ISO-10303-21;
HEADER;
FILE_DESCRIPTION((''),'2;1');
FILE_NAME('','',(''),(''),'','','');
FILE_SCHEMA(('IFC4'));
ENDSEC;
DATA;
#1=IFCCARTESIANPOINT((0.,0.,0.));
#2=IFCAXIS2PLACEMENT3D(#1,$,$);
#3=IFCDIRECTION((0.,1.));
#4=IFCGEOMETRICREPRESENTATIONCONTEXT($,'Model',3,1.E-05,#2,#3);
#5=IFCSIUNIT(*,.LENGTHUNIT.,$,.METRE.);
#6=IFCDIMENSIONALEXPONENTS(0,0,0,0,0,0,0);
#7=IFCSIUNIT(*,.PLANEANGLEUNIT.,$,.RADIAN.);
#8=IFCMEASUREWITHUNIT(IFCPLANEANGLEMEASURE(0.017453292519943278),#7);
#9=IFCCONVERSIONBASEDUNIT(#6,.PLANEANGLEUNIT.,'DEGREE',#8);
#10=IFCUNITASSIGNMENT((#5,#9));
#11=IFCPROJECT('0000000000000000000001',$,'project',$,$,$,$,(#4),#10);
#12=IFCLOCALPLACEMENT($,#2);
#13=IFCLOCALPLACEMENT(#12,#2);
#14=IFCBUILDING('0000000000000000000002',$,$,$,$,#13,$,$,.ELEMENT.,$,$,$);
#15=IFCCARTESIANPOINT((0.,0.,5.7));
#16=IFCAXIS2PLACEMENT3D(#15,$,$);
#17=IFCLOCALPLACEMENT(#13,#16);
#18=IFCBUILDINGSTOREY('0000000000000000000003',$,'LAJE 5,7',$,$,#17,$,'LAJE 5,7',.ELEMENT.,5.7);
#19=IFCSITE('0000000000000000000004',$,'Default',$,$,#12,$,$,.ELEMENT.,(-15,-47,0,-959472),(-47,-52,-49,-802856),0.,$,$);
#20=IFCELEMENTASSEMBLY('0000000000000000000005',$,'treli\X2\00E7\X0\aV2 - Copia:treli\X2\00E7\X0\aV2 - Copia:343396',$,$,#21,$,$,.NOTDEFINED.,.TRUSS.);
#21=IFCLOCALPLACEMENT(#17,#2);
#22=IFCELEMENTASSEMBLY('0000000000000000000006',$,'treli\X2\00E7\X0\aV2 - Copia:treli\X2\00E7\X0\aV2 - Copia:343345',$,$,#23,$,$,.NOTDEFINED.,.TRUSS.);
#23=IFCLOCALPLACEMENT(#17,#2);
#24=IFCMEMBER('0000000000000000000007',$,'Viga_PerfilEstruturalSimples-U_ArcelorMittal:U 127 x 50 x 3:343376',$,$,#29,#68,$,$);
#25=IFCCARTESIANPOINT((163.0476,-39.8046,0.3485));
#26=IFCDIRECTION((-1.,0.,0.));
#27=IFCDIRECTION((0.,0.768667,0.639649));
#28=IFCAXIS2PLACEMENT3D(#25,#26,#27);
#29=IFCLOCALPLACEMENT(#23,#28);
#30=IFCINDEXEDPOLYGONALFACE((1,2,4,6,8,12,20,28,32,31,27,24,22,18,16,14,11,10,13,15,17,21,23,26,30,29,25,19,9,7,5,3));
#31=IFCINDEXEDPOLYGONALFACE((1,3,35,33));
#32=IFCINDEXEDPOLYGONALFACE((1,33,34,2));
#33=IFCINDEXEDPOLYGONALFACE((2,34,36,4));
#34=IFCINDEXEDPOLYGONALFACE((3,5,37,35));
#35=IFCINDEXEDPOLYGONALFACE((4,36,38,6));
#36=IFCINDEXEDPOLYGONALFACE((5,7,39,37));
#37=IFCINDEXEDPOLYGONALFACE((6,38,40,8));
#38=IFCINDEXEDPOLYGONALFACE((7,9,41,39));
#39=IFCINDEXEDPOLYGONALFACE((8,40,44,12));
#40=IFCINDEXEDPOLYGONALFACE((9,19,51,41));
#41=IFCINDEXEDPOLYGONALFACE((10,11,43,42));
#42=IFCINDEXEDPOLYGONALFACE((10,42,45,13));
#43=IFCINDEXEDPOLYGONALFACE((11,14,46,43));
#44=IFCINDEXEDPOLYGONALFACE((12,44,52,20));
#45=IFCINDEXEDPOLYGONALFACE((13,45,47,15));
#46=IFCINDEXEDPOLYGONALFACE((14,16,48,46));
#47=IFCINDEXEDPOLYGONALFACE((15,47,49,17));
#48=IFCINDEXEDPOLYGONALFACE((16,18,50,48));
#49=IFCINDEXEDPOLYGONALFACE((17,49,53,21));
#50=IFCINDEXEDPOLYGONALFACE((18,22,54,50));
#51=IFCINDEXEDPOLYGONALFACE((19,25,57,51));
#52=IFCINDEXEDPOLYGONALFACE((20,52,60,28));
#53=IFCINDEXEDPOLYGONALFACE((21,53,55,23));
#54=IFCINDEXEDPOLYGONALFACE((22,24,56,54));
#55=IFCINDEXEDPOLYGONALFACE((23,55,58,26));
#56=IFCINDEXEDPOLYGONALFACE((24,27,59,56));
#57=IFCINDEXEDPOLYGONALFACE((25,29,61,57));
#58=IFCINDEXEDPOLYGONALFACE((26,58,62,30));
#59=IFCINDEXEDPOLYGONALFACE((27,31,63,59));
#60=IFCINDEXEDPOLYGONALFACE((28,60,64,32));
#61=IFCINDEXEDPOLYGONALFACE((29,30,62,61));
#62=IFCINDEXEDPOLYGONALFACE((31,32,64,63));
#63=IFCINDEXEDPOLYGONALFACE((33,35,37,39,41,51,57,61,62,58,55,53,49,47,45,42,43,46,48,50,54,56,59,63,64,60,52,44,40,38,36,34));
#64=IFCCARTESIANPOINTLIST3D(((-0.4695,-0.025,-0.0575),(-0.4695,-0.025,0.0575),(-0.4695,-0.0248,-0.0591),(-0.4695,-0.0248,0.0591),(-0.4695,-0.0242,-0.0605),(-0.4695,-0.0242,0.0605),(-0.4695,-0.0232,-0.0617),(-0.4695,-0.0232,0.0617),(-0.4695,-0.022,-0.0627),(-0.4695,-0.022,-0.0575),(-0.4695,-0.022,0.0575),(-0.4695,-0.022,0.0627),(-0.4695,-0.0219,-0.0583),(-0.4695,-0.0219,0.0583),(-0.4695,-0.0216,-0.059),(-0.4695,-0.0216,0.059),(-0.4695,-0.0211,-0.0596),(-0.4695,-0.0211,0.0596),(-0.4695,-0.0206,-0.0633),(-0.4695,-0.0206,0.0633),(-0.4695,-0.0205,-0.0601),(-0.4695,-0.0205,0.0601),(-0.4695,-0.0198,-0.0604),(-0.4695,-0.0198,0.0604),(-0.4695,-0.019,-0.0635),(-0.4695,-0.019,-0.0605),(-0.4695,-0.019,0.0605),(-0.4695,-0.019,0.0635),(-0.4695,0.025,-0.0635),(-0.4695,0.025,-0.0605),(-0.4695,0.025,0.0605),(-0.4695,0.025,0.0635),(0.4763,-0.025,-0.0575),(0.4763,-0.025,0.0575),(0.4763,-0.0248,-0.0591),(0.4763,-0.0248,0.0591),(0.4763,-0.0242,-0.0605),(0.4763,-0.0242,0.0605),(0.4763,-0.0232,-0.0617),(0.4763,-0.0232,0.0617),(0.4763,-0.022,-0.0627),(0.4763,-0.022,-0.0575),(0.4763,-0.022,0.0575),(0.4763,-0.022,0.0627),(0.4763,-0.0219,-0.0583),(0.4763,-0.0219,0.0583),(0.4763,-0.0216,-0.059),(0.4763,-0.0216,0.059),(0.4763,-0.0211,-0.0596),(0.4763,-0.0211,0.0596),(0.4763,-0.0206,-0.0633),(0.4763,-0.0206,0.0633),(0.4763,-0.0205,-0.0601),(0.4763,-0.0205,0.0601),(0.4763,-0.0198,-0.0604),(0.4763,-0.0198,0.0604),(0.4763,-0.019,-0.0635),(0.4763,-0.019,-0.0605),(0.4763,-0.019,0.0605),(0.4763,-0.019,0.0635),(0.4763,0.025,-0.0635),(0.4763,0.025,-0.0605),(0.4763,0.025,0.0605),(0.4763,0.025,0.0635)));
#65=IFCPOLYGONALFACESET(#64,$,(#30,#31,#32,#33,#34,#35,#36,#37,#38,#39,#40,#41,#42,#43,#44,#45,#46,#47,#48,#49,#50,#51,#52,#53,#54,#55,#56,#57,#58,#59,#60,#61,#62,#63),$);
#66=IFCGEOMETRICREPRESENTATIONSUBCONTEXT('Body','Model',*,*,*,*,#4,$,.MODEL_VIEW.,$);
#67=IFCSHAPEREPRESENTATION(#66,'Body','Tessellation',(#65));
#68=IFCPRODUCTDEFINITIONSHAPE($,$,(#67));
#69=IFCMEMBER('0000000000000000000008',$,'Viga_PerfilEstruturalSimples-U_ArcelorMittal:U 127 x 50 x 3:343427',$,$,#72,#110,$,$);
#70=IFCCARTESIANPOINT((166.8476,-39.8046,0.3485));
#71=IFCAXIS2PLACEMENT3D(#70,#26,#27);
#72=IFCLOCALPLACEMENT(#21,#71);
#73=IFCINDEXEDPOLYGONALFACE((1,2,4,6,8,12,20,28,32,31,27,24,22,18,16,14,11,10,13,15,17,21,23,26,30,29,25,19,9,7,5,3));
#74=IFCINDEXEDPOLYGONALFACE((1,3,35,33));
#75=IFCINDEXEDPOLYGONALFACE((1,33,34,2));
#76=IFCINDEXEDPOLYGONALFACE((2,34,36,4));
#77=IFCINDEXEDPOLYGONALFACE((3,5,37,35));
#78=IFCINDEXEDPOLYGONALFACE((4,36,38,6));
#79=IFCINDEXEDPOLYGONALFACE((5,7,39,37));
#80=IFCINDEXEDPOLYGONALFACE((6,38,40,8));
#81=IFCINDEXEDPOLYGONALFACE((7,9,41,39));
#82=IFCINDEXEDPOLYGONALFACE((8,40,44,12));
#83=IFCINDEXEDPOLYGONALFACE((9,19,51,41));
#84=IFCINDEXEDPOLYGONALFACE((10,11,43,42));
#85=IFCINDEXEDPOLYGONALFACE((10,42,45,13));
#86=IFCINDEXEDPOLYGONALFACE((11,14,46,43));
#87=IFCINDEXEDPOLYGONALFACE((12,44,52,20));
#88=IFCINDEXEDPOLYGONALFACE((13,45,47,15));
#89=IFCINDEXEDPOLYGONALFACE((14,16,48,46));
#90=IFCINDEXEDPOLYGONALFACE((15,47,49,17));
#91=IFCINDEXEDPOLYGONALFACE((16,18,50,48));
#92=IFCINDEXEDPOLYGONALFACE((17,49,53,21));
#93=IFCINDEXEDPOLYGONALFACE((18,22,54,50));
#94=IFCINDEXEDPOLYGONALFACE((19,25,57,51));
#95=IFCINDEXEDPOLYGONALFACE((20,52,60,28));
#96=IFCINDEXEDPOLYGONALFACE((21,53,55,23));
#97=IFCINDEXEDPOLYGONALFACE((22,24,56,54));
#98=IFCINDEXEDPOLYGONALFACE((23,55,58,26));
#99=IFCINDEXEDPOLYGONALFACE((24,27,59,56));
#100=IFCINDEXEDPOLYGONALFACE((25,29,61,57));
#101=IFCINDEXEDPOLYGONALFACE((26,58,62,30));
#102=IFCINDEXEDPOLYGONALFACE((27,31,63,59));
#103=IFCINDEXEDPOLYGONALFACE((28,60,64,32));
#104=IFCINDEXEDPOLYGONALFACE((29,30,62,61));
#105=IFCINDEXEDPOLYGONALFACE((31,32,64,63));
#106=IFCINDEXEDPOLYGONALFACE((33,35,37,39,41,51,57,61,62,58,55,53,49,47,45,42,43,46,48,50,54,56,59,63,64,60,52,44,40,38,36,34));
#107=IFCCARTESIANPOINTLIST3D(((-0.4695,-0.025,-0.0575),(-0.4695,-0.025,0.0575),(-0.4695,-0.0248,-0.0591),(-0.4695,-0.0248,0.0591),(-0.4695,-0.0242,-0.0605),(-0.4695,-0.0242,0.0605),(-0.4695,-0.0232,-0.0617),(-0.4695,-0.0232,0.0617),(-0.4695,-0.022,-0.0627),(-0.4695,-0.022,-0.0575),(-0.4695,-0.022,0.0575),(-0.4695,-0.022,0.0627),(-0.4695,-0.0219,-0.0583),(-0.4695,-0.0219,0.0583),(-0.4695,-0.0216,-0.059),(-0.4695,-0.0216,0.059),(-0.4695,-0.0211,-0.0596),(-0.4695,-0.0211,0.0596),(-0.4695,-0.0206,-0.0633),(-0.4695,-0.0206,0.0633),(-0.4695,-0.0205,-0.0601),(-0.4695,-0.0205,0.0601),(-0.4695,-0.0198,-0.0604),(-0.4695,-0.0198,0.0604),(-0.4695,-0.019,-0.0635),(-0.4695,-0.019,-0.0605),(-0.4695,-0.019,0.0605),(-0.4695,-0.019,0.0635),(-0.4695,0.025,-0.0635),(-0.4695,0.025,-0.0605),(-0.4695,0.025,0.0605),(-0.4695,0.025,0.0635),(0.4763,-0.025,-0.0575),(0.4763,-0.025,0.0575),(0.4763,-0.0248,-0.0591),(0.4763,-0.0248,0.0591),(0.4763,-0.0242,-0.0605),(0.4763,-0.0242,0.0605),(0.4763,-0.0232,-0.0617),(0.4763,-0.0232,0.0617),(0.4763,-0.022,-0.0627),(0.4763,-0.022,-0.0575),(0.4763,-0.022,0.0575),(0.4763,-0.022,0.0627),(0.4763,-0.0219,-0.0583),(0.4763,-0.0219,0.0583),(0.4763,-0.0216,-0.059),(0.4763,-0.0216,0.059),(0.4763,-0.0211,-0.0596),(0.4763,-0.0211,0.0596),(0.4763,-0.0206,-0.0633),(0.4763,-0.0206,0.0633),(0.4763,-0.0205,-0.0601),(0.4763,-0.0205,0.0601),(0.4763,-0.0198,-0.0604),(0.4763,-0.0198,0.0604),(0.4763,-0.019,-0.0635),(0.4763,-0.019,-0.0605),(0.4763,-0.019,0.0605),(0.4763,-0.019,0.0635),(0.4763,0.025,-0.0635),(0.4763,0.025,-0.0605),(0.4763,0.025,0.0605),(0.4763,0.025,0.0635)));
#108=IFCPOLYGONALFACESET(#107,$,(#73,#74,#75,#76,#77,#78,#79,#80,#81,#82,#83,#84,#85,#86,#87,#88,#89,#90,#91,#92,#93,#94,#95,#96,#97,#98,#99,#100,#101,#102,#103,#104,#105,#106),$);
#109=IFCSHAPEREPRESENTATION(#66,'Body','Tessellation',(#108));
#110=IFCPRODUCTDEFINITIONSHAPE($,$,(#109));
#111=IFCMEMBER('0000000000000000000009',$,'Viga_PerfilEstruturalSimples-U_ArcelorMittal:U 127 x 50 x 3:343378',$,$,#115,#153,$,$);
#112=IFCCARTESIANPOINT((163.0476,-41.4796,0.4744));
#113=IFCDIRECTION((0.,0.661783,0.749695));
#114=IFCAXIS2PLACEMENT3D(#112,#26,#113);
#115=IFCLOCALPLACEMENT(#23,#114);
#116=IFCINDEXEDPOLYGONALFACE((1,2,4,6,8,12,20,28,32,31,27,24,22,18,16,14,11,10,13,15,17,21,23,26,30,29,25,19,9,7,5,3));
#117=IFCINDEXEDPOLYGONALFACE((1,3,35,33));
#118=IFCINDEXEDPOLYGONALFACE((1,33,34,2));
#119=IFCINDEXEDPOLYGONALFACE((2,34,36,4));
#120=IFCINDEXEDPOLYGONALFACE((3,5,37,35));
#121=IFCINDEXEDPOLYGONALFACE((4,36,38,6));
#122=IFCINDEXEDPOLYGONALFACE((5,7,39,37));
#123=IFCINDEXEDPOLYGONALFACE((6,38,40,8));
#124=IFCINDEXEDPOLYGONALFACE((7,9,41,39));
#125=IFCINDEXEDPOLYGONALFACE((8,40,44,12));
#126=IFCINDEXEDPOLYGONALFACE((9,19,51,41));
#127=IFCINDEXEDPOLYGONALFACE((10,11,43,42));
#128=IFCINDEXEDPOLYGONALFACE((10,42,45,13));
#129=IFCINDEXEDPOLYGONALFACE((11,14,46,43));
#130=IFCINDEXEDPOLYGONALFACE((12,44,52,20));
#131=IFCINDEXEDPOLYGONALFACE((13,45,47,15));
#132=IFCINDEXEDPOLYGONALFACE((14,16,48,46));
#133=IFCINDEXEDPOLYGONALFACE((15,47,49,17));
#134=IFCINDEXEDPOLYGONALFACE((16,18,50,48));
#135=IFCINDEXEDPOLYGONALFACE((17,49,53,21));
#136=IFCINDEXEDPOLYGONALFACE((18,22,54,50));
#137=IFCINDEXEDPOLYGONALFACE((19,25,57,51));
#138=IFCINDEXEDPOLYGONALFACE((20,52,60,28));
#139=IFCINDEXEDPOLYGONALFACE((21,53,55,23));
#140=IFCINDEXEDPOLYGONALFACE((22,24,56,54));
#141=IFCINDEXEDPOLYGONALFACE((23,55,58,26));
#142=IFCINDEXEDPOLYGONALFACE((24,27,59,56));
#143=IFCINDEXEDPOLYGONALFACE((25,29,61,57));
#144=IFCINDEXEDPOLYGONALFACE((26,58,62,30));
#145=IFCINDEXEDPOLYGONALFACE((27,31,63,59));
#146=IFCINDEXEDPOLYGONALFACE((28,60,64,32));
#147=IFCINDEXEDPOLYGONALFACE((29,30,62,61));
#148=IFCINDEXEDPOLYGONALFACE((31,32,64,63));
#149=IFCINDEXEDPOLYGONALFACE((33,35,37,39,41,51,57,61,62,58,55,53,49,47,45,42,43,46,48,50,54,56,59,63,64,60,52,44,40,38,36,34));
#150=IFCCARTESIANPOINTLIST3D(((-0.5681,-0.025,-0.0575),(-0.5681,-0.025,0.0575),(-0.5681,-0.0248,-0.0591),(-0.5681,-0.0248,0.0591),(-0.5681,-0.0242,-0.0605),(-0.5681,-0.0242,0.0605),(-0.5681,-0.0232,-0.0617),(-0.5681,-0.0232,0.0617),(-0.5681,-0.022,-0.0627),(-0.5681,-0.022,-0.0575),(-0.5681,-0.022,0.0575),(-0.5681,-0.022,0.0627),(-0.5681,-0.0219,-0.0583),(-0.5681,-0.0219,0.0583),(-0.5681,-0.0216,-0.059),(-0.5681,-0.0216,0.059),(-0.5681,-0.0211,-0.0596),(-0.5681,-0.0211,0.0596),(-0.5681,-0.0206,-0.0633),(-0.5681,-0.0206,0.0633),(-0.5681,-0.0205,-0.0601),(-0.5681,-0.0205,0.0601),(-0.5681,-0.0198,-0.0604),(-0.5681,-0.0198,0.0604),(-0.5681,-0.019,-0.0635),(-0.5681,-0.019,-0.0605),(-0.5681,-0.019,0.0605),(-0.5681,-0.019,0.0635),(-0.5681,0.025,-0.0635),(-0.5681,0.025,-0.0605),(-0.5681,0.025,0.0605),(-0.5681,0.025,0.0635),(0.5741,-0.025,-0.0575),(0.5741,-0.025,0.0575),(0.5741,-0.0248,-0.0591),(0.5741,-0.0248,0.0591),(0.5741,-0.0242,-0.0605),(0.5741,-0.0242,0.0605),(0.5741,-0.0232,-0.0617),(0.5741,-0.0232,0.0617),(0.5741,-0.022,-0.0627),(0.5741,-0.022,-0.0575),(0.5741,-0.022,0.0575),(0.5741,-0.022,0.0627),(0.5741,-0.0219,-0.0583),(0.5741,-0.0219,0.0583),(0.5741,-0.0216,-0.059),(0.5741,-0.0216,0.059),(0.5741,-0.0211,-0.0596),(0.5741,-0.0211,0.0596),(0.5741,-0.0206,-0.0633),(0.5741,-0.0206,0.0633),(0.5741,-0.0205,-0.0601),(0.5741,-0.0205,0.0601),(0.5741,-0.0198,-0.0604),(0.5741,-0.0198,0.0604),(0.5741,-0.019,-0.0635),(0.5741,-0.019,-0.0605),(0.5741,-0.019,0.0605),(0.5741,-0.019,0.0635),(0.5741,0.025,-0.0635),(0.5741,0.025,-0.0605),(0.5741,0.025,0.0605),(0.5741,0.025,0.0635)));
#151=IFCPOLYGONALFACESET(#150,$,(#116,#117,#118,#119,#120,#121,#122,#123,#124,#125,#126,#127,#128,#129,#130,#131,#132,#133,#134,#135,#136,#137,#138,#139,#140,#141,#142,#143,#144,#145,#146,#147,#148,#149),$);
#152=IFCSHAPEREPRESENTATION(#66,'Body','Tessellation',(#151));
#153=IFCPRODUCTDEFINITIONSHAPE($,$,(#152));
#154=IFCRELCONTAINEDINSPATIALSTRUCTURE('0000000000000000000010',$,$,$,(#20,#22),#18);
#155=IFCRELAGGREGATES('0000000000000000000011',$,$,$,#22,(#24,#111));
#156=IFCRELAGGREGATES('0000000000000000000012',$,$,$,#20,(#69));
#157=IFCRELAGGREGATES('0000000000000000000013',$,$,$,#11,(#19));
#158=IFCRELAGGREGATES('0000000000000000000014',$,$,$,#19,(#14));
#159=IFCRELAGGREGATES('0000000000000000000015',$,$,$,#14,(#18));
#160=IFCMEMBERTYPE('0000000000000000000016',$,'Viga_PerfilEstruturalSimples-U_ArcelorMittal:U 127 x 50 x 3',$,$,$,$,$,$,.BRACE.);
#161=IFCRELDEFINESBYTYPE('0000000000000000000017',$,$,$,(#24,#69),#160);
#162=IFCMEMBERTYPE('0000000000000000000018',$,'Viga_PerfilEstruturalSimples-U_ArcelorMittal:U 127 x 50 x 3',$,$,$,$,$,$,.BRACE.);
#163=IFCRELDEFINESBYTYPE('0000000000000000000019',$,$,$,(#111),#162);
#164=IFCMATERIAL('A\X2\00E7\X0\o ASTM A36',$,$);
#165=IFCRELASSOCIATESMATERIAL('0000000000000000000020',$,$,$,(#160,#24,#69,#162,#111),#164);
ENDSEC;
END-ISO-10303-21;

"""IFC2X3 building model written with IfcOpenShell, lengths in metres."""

from ifc_helpers import new_model, entity, si_unit, converted_unit, direction, frame, frame_2d, origin, place, context, subcontext, project, spatial, polyline, circle_curve, parameter, trimmed, segment, composite_curve, outline, extrude, source, transform, mapped, material, type_object, type_shapes, element, aggregate, save


model = new_model("IFC2X3")

# Units and contexts
model_context = context("Model", 3, precision=1e-05, world=origin(), true_north=direction((0.0, 1.0)))
body_context = subcontext(model_context, "Body", "Model", "MODEL_VIEW")
ifc_project = project(units=[si_unit("LENGTHUNIT", "METRE"), converted_unit("PLANEANGLEUNIT", "DEGREE", entity("IfcPlaneAngleMeasure", 0.017453292519943278), si_unit("PLANEANGLEUNIT", "RADIAN"), dimensions=[0, 0, 0, 0, 0, 0, 0])], contexts=[model_context])

# Site, building, storey
site_placement = place(None, origin())
site = spatial("IfcSite", under=ifc_project, at=site_placement, Name="Default", CompositionType="ELEMENT", RefLatitude=(-15, -47, 0, -959472), RefLongitude=(-47, -52, -49, -802856), RefElevation=0.0)
building_placement = place(site_placement, origin())
building = spatial("IfcBuilding", under=site, at=building_placement, CompositionType="ELEMENT")
storey_placement = place(building_placement, frame((0.0, 0.0, 5.7)))
storey = spatial("IfcBuildingStorey", under=building, at=storey_placement, Name="LAJE 5,7", LongName="LAJE 5,7", CompositionType="ELEMENT", Elevation=5.7)

# Element assembly
assembly_1_placement = place(storey_placement, origin())
assembly_1 = element("IfcElementAssembly", 1, at=assembly_1_placement, inside=storey, Name="treliçaV2 - Copia:treliçaV2 - Copia:343396", AssemblyPlace="NOTDEFINED", PredefinedType="TRUSS")
ifc_material = material(Name="Aço ASTM A36")

# Element assembly
assembly_2_placement = place(storey_placement, origin())
assembly_2 = element("IfcElementAssembly", 2, at=assembly_2_placement, inside=storey, Name="treliçaV2 - Copia:treliçaV2 - Copia:343345", AssemblyPlace="NOTDEFINED", PredefinedType="TRUSS")

# Members
member_type_1 = type_object("IfcMemberType", Name="Viga_PerfilEstruturalSimples-U_ArcelorMittal:U 127 x 50 x 3", PredefinedType="BRACE", material=ifc_material)
shared_shape_1 = source(origin(), body_context, "Body", "SweptSolid", [
    extrude(outline(composite_curve([segment(polyline([(-0.0575, -0.0192), (0.0575, -0.0192)]), True, "CONTINUOUS"), segment(trimmed(circle_curve(frame_2d((0.0575, -0.0132), x_axis=(0.0, 1.0)), 0.006), [parameter(180.0)], [parameter(270.0)], True, "PARAMETER"), True, "CONTINUOUS"), segment(polyline([(0.0635, -0.0132), (0.0635, 0.0308)]), True, "CONTINUOUS"), segment(polyline([(0.0635, 0.0308), (0.0605, 0.0308)]), True, "CONTINUOUS"), segment(polyline([(0.0605, 0.0308), (0.0605, -0.0132)]), True, "CONTINUOUS"), segment(trimmed(circle_curve(frame_2d((0.0575, -0.0132), x_axis=(0.0, 1.0)), 0.003), [parameter(180.0)], [parameter(270.0)], True, "PARAMETER"), False, "CONTINUOUS"), segment(polyline([(0.0575, -0.0162), (-0.0575, -0.0162)]), True, "CONTINUOUS"), segment(trimmed(circle_curve(frame_2d((-0.0575, -0.0132), x_axis=(0.0, 1.0)), 0.003), [parameter(90.0)], [parameter(180.0)], True, "PARAMETER"), False, "CONTINUOUS"), segment(polyline([(-0.0605, -0.0132), (-0.0605, 0.0308)]), True, "CONTINUOUS"), segment(polyline([(-0.0605, 0.0308), (-0.0635, 0.0308)]), True, "CONTINUOUS"), segment(polyline([(-0.0635, 0.0308), (-0.0635, -0.0132)]), True, "CONTINUOUS"), segment(trimmed(circle_curve(frame_2d((-0.0575, -0.0132), x_axis=(0.0, 1.0)), 0.006), [parameter(90.0)], [parameter(180.0)], True, "PARAMETER"), True, "CONTINUOUS")], self_intersect=False)), frame((-0.4695, -0.0058, 0.0), z_axis=(1.0, 0.0, 0.0), x_axis=(0.0, 0.0, -1.0)), (0.0, 0.0, 1.0), 0.9459),
])
type_shapes(member_type_1, [shared_shape_1])
member_1_placement = place(assembly_2_placement, frame((163.0476, -39.8046, 0.3485), z_axis=(-1.0, 0.0, 0.0), x_axis=(0.0, 0.768667, 0.639649)))
member_1 = element("IfcMember", 3, at=member_1_placement, type_object=member_type_1, material=ifc_material, Name="Viga_PerfilEstruturalSimples-U_ArcelorMittal:U 127 x 50 x 3:343376", context=body_context, shape_type="MappedRepresentation", body=[
    mapped(shared_shape_1, transform((0.0, 0.0, 0.0), scale=1.0)),
])
member_2_placement = place(assembly_1_placement, frame((166.8476, -39.8046, 0.3485), z_axis=(-1.0, 0.0, 0.0), x_axis=(0.0, 0.768667, 0.639649)))
member_2 = element("IfcMember", 4, at=member_2_placement, type_object=member_type_1, material=ifc_material, Name="Viga_PerfilEstruturalSimples-U_ArcelorMittal:U 127 x 50 x 3:343427", context=body_context, shape_type="MappedRepresentation", body=[
    mapped(shared_shape_1, transform((0.0, 0.0, 0.0), scale=1.0)),
])
member_type_2 = type_object("IfcMemberType", Name="Viga_PerfilEstruturalSimples-U_ArcelorMittal:U 127 x 50 x 3", PredefinedType="BRACE", material=ifc_material)
shared_shape_2 = source(origin(), body_context, "Body", "SweptSolid", [
    extrude(outline(composite_curve([segment(polyline([(-0.0575, -0.0192), (0.0575, -0.0192)]), True, "CONTINUOUS"), segment(trimmed(circle_curve(frame_2d((0.0575, -0.0132), x_axis=(0.0, 1.0)), 0.006), [parameter(180.0)], [parameter(270.0)], True, "PARAMETER"), True, "CONTINUOUS"), segment(polyline([(0.0635, -0.0132), (0.0635, 0.0308)]), True, "CONTINUOUS"), segment(polyline([(0.0635, 0.0308), (0.0605, 0.0308)]), True, "CONTINUOUS"), segment(polyline([(0.0605, 0.0308), (0.0605, -0.0132)]), True, "CONTINUOUS"), segment(trimmed(circle_curve(frame_2d((0.0575, -0.0132), x_axis=(0.0, 1.0)), 0.003), [parameter(180.0)], [parameter(270.0)], True, "PARAMETER"), False, "CONTINUOUS"), segment(polyline([(0.0575, -0.0162), (-0.0575, -0.0162)]), True, "CONTINUOUS"), segment(trimmed(circle_curve(frame_2d((-0.0575, -0.0132), x_axis=(0.0, 1.0)), 0.003), [parameter(90.0)], [parameter(180.0)], True, "PARAMETER"), False, "CONTINUOUS"), segment(polyline([(-0.0605, -0.0132), (-0.0605, 0.0308)]), True, "CONTINUOUS"), segment(polyline([(-0.0605, 0.0308), (-0.0635, 0.0308)]), True, "CONTINUOUS"), segment(polyline([(-0.0635, 0.0308), (-0.0635, -0.0132)]), True, "CONTINUOUS"), segment(trimmed(circle_curve(frame_2d((-0.0575, -0.0132), x_axis=(0.0, 1.0)), 0.006), [parameter(90.0)], [parameter(180.0)], True, "PARAMETER"), True, "CONTINUOUS")], self_intersect=False)), frame((-0.5681, -0.0058, 0.0), z_axis=(1.0, 0.0, 0.0), x_axis=(0.0, 0.0, -1.0)), (0.0, 0.0, 1.0), 1.1422),
])
type_shapes(member_type_2, [shared_shape_2])
member_3_placement = place(assembly_2_placement, frame((163.0476, -41.4796, 0.4744), z_axis=(-1.0, 0.0, 0.0), x_axis=(0.0, 0.661783, 0.749695)))
member_3 = element("IfcMember", 5, at=member_3_placement, type_object=member_type_2, material=ifc_material, Name="Viga_PerfilEstruturalSimples-U_ArcelorMittal:U 127 x 50 x 3:343378", context=body_context, shape_type="MappedRepresentation", body=[
    mapped(shared_shape_2, transform((0.0, 0.0, 0.0), scale=1.0)),
])
aggregate(assembly_2, [member_1, member_3])
aggregate(assembly_1, [member_2])

save(model, "model.ifc")
